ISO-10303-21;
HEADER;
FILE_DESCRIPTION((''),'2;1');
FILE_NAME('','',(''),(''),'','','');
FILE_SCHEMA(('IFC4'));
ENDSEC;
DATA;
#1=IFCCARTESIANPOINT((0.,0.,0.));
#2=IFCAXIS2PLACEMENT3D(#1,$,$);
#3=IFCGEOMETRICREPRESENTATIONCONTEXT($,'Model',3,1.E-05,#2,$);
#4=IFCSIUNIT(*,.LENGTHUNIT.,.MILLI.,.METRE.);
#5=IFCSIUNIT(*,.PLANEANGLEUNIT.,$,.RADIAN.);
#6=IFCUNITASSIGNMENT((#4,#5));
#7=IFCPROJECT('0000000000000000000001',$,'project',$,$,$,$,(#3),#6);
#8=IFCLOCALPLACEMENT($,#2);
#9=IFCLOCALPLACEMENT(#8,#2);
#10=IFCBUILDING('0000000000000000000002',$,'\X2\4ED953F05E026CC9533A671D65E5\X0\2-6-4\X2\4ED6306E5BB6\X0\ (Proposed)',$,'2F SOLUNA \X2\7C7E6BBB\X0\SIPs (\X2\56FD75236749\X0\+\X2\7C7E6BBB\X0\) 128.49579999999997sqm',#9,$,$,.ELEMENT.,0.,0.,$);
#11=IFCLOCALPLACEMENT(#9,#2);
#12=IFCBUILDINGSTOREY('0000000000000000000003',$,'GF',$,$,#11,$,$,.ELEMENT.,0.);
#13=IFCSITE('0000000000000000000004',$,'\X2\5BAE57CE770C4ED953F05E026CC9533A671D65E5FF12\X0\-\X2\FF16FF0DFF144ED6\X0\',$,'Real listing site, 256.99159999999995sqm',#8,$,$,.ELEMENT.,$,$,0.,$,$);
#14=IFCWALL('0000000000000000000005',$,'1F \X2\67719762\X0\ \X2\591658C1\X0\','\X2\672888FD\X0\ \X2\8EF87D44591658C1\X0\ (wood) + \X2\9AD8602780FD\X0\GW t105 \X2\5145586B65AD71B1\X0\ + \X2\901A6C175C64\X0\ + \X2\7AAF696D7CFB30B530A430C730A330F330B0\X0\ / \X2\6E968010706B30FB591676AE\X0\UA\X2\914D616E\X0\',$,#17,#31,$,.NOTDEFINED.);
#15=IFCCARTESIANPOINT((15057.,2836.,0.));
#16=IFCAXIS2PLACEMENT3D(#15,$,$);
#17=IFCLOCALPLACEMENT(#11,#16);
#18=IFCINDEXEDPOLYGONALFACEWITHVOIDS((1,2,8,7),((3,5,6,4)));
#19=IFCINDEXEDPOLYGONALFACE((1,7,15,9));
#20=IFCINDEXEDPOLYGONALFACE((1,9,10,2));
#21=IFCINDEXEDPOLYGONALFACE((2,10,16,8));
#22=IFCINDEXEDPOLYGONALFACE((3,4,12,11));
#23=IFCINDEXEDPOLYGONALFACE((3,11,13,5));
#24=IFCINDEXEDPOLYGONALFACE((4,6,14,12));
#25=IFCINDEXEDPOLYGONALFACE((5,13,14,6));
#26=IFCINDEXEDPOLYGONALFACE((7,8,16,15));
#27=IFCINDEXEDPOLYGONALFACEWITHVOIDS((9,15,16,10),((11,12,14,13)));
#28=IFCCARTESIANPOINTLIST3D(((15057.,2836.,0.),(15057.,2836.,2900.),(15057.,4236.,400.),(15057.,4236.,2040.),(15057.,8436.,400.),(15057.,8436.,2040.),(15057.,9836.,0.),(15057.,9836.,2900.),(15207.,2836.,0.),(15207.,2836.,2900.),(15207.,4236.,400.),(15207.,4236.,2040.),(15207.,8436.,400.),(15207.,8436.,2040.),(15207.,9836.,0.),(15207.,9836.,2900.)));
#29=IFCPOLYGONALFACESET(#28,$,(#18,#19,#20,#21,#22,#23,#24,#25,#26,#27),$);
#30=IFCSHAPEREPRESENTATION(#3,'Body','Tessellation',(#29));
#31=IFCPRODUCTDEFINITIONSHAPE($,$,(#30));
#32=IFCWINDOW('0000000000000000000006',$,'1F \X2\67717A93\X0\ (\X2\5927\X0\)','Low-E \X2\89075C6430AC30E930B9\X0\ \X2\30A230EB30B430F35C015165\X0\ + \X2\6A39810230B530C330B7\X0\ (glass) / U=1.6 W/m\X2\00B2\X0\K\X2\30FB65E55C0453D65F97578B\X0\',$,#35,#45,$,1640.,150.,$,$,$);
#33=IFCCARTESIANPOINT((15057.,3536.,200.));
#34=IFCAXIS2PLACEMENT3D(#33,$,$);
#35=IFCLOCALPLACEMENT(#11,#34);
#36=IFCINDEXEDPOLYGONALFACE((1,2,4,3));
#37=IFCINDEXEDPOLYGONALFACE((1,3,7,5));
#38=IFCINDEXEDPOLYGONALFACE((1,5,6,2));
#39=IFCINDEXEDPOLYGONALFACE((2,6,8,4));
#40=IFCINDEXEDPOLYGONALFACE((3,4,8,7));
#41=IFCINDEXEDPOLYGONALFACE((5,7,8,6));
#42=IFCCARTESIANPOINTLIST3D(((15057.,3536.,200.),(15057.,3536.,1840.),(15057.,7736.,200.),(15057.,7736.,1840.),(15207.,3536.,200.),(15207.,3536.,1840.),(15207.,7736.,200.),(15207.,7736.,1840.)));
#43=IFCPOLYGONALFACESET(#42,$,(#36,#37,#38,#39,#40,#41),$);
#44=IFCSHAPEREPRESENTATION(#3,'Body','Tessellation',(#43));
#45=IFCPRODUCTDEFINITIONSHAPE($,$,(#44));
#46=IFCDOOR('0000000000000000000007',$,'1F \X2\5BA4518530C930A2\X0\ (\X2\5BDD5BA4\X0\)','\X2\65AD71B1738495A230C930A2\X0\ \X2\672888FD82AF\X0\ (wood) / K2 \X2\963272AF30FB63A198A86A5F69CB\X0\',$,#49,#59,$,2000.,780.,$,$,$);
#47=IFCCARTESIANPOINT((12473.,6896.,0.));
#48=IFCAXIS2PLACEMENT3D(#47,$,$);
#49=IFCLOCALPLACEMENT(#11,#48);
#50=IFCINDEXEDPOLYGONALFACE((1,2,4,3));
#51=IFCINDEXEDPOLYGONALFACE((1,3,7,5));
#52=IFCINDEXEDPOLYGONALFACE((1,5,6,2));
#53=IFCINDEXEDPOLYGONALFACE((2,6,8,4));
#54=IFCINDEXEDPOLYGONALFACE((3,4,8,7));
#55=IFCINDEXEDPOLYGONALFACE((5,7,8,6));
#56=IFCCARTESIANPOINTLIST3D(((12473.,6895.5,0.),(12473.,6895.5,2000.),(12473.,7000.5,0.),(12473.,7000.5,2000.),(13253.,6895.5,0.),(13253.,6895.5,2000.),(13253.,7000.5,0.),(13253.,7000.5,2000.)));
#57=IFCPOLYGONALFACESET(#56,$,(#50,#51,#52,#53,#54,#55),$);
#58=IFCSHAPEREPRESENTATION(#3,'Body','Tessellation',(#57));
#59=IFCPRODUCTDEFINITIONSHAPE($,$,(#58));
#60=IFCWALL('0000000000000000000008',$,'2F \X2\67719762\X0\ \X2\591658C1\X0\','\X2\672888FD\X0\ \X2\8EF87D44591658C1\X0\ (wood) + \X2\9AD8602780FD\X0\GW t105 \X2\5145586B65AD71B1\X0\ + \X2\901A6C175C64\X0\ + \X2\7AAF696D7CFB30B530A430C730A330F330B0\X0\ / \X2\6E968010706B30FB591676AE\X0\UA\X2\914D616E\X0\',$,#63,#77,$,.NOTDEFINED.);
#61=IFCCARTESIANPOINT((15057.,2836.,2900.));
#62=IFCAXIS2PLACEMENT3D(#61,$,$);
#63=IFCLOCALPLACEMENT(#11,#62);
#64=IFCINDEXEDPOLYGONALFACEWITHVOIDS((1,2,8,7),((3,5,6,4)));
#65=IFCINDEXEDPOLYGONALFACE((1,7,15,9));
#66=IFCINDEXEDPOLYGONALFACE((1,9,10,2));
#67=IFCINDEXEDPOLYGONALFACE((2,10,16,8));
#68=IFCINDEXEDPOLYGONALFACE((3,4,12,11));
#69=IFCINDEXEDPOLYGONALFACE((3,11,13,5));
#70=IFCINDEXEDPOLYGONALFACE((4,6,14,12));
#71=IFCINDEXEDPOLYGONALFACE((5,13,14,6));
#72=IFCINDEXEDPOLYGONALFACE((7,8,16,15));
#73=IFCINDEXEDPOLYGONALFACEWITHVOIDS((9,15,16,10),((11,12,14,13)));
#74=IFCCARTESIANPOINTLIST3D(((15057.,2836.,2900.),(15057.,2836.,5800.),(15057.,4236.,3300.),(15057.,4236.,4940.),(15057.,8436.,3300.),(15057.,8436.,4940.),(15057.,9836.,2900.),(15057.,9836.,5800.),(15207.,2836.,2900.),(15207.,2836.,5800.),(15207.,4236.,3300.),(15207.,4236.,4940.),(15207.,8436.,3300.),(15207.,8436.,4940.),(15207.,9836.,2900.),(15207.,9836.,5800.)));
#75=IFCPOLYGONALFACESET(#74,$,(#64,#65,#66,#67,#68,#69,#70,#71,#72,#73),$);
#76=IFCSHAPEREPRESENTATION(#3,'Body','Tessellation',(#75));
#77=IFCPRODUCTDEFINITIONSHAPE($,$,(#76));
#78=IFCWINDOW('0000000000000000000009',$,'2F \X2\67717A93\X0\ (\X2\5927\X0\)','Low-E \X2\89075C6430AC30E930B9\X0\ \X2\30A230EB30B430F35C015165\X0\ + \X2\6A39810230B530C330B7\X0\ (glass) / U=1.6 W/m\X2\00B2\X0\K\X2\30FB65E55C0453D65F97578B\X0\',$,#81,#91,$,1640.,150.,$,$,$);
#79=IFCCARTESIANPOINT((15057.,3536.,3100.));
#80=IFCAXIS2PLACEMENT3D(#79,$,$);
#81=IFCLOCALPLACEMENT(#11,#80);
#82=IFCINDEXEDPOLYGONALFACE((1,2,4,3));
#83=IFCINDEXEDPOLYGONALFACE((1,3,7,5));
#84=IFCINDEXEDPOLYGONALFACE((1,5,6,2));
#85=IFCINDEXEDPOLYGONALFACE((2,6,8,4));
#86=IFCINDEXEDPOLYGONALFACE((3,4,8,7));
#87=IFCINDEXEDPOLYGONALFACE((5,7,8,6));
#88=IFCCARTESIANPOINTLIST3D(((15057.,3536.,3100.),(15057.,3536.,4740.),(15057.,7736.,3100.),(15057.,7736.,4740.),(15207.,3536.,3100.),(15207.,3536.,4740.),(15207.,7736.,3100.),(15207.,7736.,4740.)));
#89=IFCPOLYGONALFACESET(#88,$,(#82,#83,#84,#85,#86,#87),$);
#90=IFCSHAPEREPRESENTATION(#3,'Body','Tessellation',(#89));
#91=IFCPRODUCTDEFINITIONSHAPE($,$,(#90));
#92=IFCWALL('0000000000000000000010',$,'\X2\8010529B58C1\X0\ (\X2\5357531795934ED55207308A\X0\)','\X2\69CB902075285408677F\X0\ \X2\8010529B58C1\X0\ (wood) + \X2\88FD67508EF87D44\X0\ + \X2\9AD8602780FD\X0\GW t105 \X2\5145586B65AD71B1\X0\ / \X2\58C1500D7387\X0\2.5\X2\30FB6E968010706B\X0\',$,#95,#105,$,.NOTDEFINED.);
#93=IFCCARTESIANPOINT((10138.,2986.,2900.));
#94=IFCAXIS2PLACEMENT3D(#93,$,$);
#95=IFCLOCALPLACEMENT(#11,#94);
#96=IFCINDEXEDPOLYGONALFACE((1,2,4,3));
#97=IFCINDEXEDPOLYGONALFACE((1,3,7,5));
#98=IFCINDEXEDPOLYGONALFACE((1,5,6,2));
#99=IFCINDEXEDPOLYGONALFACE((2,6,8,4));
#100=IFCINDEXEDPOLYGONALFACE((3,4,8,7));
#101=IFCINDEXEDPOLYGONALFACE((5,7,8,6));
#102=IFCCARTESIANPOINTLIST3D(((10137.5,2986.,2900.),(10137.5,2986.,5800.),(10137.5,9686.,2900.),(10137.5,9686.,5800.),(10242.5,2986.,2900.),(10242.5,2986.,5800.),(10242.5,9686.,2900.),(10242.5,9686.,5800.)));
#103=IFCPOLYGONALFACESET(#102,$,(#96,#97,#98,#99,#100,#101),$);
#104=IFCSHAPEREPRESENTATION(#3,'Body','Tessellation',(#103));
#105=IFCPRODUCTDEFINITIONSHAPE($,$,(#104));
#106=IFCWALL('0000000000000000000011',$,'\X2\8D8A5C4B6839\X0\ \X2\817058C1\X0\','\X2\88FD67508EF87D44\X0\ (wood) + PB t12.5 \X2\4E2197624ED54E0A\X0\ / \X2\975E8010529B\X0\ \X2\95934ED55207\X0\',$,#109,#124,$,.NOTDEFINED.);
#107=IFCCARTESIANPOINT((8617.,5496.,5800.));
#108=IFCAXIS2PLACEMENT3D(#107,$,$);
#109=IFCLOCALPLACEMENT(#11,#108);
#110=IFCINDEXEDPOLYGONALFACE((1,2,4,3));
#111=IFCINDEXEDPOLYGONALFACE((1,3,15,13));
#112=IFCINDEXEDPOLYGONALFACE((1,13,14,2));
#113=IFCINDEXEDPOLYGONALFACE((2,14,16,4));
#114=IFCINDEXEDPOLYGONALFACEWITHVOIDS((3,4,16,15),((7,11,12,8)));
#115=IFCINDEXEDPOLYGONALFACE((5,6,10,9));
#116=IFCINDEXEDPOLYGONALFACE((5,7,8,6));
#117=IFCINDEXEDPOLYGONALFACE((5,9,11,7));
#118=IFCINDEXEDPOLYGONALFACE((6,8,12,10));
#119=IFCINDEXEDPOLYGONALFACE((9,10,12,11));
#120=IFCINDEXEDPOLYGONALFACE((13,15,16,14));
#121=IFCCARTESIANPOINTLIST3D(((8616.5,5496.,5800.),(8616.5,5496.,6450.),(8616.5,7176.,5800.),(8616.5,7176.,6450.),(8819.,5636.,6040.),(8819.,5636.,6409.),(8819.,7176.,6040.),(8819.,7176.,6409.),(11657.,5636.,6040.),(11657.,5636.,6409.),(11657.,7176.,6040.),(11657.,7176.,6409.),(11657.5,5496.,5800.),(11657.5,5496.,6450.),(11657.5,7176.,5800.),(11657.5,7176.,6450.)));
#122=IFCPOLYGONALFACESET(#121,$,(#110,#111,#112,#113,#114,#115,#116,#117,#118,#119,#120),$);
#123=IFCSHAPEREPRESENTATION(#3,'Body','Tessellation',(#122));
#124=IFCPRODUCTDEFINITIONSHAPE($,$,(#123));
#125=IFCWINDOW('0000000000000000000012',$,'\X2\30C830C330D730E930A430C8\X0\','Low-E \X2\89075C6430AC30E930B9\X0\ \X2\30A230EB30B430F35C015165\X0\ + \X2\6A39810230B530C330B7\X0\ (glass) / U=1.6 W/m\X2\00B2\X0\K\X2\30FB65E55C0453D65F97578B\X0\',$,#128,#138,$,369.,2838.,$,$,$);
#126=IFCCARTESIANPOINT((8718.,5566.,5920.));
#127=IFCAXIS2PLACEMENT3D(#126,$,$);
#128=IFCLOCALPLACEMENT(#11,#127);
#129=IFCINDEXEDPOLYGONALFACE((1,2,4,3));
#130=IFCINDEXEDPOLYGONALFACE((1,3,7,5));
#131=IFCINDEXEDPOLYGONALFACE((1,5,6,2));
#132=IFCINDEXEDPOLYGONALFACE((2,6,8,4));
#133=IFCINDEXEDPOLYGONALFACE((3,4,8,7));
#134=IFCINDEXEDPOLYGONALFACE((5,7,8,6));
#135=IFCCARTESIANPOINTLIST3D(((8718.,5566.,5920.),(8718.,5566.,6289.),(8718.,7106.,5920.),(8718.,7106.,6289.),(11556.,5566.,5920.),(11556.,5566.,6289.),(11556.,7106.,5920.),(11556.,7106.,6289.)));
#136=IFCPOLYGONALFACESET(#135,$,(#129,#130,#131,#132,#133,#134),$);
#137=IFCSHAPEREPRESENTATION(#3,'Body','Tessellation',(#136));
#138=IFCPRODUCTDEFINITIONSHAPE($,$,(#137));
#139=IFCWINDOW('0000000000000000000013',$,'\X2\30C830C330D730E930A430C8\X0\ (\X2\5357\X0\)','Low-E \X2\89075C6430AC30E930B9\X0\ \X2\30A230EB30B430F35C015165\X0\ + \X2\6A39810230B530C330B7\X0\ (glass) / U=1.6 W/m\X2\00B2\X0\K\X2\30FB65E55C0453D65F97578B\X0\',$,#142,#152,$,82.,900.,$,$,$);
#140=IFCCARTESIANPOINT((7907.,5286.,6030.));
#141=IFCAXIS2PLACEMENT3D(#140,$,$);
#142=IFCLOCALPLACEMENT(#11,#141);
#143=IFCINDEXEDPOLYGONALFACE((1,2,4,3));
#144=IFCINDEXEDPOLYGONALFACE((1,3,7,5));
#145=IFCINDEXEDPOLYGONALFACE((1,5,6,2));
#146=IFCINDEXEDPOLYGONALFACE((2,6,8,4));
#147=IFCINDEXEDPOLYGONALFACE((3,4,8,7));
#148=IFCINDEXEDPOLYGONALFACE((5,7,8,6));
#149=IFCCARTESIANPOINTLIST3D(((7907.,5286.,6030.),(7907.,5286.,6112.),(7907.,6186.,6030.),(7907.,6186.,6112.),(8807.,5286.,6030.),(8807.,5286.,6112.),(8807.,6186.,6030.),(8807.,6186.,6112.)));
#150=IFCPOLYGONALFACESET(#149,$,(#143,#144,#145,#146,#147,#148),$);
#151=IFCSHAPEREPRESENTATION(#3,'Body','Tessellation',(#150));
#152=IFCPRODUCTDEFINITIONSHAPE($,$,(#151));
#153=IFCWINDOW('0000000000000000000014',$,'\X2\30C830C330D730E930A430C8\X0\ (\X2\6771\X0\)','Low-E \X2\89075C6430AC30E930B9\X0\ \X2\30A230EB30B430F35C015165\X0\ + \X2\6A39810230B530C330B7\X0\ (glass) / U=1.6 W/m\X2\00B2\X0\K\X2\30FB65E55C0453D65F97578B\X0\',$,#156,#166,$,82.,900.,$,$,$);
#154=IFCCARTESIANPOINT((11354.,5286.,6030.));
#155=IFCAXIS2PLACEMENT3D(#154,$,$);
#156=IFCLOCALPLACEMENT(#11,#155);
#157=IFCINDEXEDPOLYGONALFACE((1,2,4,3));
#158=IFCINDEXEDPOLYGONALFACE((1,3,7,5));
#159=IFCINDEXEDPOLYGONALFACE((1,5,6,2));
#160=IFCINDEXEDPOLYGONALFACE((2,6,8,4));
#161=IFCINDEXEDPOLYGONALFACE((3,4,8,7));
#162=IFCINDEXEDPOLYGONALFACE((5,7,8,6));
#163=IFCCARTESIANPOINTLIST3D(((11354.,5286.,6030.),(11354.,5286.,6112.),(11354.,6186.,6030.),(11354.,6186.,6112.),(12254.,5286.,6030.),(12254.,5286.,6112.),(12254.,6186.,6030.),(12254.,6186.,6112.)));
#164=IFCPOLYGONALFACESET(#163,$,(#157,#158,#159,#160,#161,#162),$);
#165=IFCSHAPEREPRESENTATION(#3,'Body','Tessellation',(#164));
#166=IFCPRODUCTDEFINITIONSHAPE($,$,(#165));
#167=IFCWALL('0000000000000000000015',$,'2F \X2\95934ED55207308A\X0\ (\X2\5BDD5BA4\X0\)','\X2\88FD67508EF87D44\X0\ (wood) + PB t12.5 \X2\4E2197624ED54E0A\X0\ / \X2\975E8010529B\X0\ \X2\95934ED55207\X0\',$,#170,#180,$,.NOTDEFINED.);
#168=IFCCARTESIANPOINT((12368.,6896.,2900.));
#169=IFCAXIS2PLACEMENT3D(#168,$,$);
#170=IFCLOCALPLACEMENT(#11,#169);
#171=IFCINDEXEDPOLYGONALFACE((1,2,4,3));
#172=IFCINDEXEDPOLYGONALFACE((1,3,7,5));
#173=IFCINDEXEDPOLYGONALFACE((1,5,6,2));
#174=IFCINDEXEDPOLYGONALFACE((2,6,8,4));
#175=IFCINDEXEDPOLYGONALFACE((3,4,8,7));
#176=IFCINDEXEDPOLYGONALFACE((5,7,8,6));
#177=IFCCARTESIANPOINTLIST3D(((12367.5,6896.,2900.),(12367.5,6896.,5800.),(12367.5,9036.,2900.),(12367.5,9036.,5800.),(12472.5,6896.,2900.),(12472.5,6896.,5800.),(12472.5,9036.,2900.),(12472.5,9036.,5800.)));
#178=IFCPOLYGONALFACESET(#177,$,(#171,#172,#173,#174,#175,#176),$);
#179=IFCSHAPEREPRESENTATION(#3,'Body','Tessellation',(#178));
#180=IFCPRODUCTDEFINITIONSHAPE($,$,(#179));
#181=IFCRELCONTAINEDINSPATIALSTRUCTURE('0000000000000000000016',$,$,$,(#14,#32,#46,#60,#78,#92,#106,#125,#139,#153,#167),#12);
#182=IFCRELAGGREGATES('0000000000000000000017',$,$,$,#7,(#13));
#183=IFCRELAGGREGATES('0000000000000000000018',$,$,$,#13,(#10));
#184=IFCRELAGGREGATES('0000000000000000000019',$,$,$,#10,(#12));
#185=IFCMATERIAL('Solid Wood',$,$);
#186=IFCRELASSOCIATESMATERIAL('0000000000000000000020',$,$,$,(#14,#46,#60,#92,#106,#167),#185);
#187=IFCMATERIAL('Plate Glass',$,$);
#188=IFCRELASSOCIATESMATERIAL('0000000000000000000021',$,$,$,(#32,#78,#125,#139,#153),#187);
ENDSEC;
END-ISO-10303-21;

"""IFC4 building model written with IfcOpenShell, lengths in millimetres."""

from ifc_helpers import new_model, si_unit, frame, frame_2d, origin, place, context, project, spatial, rectangle, extrude, material, element, fill, save


model = new_model("IFC4")

# Units and contexts
model_context = context("Model", 3, precision=1e-05, world=origin())
ifc_project = project(units=[si_unit("LENGTHUNIT", "METRE", prefix="MILLI"), si_unit("PLANEANGLEUNIT", "RADIAN")], contexts=[model_context])

# Site, building, storey
site_placement = place(None, origin())
site = spatial("IfcSite", under=ifc_project, at=site_placement, Name="宮城県仙台市泉区朝日２-６－４他", ObjectType="Real listing site, 256.99159999999995sqm", CompositionType="ELEMENT", RefElevation=0.0)
building_placement = place(site_placement, origin())
building = spatial("IfcBuilding", under=site, at=building_placement, Name="仙台市泉区朝日2-6-4他の家 (Proposed)", ObjectType="2F SOLUNA 籾殻SIPs (国産杉+籾殻) 128.49579999999997sqm", CompositionType="ELEMENT", ElevationOfRefHeight=0.0, ElevationOfTerrain=0.0)
storey_placement = place(building_placement, origin())
storey = spatial("IfcBuildingStorey", under=building, at=storey_placement, Name="GF", CompositionType="ELEMENT", Elevation=0.0)

# Wall, opening, window
ifc_material_1 = material(Name="Solid Wood")
wall_1_placement = place(storey_placement, frame((15057.0, 2836.0, 0.0)))
wall_1 = element("IfcWall", 1, at=wall_1_placement, inside=storey, material=ifc_material_1, Name="1F 東面 外壁", Description="木製 軸組外壁 (wood) + 高性能GW t105 充填断熱 + 通気層 + 窯業系サイディング / 準耐火・外皮UA配慮", PredefinedType="NOTDEFINED", context=model_context, shape_type="SweptSolid", body=[
    extrude(rectangle(XDim=150.0, YDim=7000.0, at=frame_2d((75.0, 3500.0))), frame((15057.0, 2836.0, 0.0)), (0.0, 0.0, 1.0), 2900.0),
])
opening_1_placement = place(storey_placement, frame((15057.0, 3536.0, 200.0)))
opening_1 = element("IfcOpeningElement", 2, at=opening_1_placement, cuts=wall_1, PredefinedType="NOTDEFINED", context=model_context, shape_type="SweptSolid", body=[
    extrude(rectangle(XDim=150.0, YDim=4200.0, at=frame_2d((75.0, 2100.0))), frame((15057.0, 3536.0, 200.0)), (0.0, 0.0, 1.0), 1640.0),
])
ifc_material_2 = material(Name="Plate Glass")
window_1_placement = place(storey_placement, frame((15057.0, 3536.0, 200.0)))
window_1 = element("IfcWindow", 3, at=window_1_placement, inside=storey, material=ifc_material_2, Name="1F 東窓 (大)", Description="Low-E 複層ガラス アルゴン封入 + 樹脂サッシ (glass) / U=1.6 W/m²K・日射取得型", OverallHeight=1640.0, OverallWidth=150.0, context=model_context, shape_type="SweptSolid", body=[
    extrude(rectangle(XDim=150.0, YDim=4200.0, at=frame_2d((75.0, 2100.0))), frame((15057.0, 3536.0, 200.0)), (0.0, 0.0, 1.0), 1640.0),
])
fill(opening_1, window_1)

# Door
door_1_placement = place(storey_placement, frame((12473.0, 6896.0, 0.0)))
element("IfcDoor", 4, at=door_1_placement, inside=storey, material=ifc_material_1, Name="1F 室内ドア (寝室)", Description="断熱玄関ドア 木製芯 (wood) / K2 防犯・採風機構", OverallHeight=2000.0, OverallWidth=780.0, context=model_context, shape_type="SweptSolid", body=[
    extrude(rectangle(XDim=780.0, YDim=105.0, at=frame_2d((390.0, 52.0))), frame((12473.0, 6896.0, 0.0)), (0.0, 0.0, 1.0), 2000.0),
])

# Wall, opening, window
wall_2_placement = place(storey_placement, frame((15057.0, 2836.0, 2900.0)))
wall_2 = element("IfcWall", 5, at=wall_2_placement, inside=storey, material=ifc_material_1, Name="2F 東面 外壁", Description="木製 軸組外壁 (wood) + 高性能GW t105 充填断熱 + 通気層 + 窯業系サイディング / 準耐火・外皮UA配慮", PredefinedType="NOTDEFINED", context=model_context, shape_type="SweptSolid", body=[
    extrude(rectangle(XDim=150.0, YDim=7000.0, at=frame_2d((75.0, 3500.0))), frame((15057.0, 2836.0, 2900.0)), (0.0, 0.0, 1.0), 2900.0),
])
opening_2_placement = place(storey_placement, frame((15057.0, 3536.0, 3100.0)))
opening_2 = element("IfcOpeningElement", 6, at=opening_2_placement, cuts=wall_2, PredefinedType="NOTDEFINED", context=model_context, shape_type="SweptSolid", body=[
    extrude(rectangle(XDim=150.0, YDim=4200.0, at=frame_2d((75.0, 2100.0))), frame((15057.0, 3536.0, 3100.0)), (0.0, 0.0, 1.0), 1640.0),
])
window_2_placement = place(storey_placement, frame((15057.0, 3536.0, 3100.0)))
window_2 = element("IfcWindow", 7, at=window_2_placement, inside=storey, material=ifc_material_2, Name="2F 東窓 (大)", Description="Low-E 複層ガラス アルゴン封入 + 樹脂サッシ (glass) / U=1.6 W/m²K・日射取得型", OverallHeight=1640.0, OverallWidth=150.0, context=model_context, shape_type="SweptSolid", body=[
    extrude(rectangle(XDim=150.0, YDim=4200.0, at=frame_2d((75.0, 2100.0))), frame((15057.0, 3536.0, 3100.0)), (0.0, 0.0, 1.0), 1640.0),
])
fill(opening_2, window_2)

# Wall
wall_3_placement = place(storey_placement, frame((10138.0, 2986.0, 2900.0)))
element("IfcWall", 8, at=wall_3_placement, inside=storey, material=ifc_material_1, Name="耐力壁 (南北間仕切り)", Description="構造用合板 耐力壁 (wood) + 製材軸組 + 高性能GW t105 充填断熱 / 壁倍率2.5・準耐火", PredefinedType="NOTDEFINED", context=model_context, shape_type="SweptSolid", body=[
    extrude(rectangle(XDim=105.0, YDim=6700.0, at=frame_2d((52.0, 3350.0))), frame((10138.0, 2986.0, 2900.0)), (0.0, 0.0, 1.0), 2900.0),
])

# Wall, openings, windows
wall_4_placement = place(storey_placement, frame((8617.0, 5496.0, 5800.0)))
wall_4 = element("IfcWall", 9, at=wall_4_placement, inside=storey, material=ifc_material_1, Name="越屋根 腰壁", Description="製材軸組 (wood) + PB t12.5 両面仕上 / 非耐力 間仕切", PredefinedType="NOTDEFINED", context=model_context, shape_type="SweptSolid", body=[
    extrude(rectangle(XDim=3041.0, YDim=1680.0, at=frame_2d((1520.0, 840.0))), frame((8617.0, 5496.0, 5800.0)), (0.0, 0.0, 1.0), 650.0),
])
opening_3_placement = place(storey_placement, frame((8718.0, 5566.0, 5920.0)))
opening_3 = element("IfcOpeningElement", 10, at=opening_3_placement, cuts=wall_4, PredefinedType="NOTDEFINED", context=model_context, shape_type="SweptSolid", body=[
    extrude(rectangle(XDim=2838.0, YDim=1540.0, at=frame_2d((1419.0, 770.0))), frame((8718.0, 5566.0, 5920.0)), (0.0, 0.0, 1.0), 369.0),
])
opening_4_placement = place(storey_placement, frame((7907.0, 5286.0, 6030.0)))
opening_4 = element("IfcOpeningElement", 11, at=opening_4_placement, cuts=wall_4, PredefinedType="NOTDEFINED", context=model_context, shape_type="SweptSolid", body=[
    extrude(rectangle(XDim=900.0, YDim=900.0, at=frame_2d((450.0, 450.0))), frame((7907.0, 5286.0, 6030.0)), (0.0, 0.0, 1.0), 82.0),
])
opening_5_placement = place(storey_placement, frame((11354.0, 5286.0, 6030.0)))
opening_5 = element("IfcOpeningElement", 12, at=opening_5_placement, cuts=wall_4, PredefinedType="NOTDEFINED", context=model_context, shape_type="SweptSolid", body=[
    extrude(rectangle(XDim=900.0, YDim=900.0, at=frame_2d((450.0, 450.0))), frame((11354.0, 5286.0, 6030.0)), (0.0, 0.0, 1.0), 82.0),
])
window_3_placement = place(storey_placement, frame((8718.0, 5566.0, 5920.0)))
window_3 = element("IfcWindow", 13, at=window_3_placement, inside=storey, material=ifc_material_2, Name="トップライト", Description="Low-E 複層ガラス アルゴン封入 + 樹脂サッシ (glass) / U=1.6 W/m²K・日射取得型", OverallHeight=369.0, OverallWidth=2838.0, context=model_context, shape_type="SweptSolid", body=[
    extrude(rectangle(XDim=2838.0, YDim=1540.0, at=frame_2d((1419.0, 770.0))), frame((8718.0, 5566.0, 5920.0)), (0.0, 0.0, 1.0), 369.0),
])
fill(opening_3, window_3)
window_4_placement = place(storey_placement, frame((7907.0, 5286.0, 6030.0)))
window_4 = element("IfcWindow", 14, at=window_4_placement, inside=storey, material=ifc_material_2, Name="トップライト (南)", Description="Low-E 複層ガラス アルゴン封入 + 樹脂サッシ (glass) / U=1.6 W/m²K・日射取得型", OverallHeight=82.0, OverallWidth=900.0, context=model_context, shape_type="SweptSolid", body=[
    extrude(rectangle(XDim=900.0, YDim=900.0, at=frame_2d((450.0, 450.0))), frame((7907.0, 5286.0, 6030.0)), (0.0, 0.0, 1.0), 82.0),
])
fill(opening_4, window_4)
window_5_placement = place(storey_placement, frame((11354.0, 5286.0, 6030.0)))
window_5 = element("IfcWindow", 15, at=window_5_placement, inside=storey, material=ifc_material_2, Name="トップライト (東)", Description="Low-E 複層ガラス アルゴン封入 + 樹脂サッシ (glass) / U=1.6 W/m²K・日射取得型", OverallHeight=82.0, OverallWidth=900.0, context=model_context, shape_type="SweptSolid", body=[
    extrude(rectangle(XDim=900.0, YDim=900.0, at=frame_2d((450.0, 450.0))), frame((11354.0, 5286.0, 6030.0)), (0.0, 0.0, 1.0), 82.0),
])
fill(opening_5, window_5)

# Wall
wall_5_placement = place(storey_placement, frame((12368.0, 6896.0, 2900.0)))
element("IfcWall", 16, at=wall_5_placement, inside=storey, material=ifc_material_1, Name="2F 間仕切り (寝室)", Description="製材軸組 (wood) + PB t12.5 両面仕上 / 非耐力 間仕切", PredefinedType="NOTDEFINED", context=model_context, shape_type="SweptSolid", body=[
    extrude(rectangle(XDim=105.0, YDim=2140.0, at=frame_2d((52.0, 1070.0))), frame((12368.0, 6896.0, 2900.0)), (0.0, 0.0, 1.0), 2900.0),
])

save(model, "model.ifc")
